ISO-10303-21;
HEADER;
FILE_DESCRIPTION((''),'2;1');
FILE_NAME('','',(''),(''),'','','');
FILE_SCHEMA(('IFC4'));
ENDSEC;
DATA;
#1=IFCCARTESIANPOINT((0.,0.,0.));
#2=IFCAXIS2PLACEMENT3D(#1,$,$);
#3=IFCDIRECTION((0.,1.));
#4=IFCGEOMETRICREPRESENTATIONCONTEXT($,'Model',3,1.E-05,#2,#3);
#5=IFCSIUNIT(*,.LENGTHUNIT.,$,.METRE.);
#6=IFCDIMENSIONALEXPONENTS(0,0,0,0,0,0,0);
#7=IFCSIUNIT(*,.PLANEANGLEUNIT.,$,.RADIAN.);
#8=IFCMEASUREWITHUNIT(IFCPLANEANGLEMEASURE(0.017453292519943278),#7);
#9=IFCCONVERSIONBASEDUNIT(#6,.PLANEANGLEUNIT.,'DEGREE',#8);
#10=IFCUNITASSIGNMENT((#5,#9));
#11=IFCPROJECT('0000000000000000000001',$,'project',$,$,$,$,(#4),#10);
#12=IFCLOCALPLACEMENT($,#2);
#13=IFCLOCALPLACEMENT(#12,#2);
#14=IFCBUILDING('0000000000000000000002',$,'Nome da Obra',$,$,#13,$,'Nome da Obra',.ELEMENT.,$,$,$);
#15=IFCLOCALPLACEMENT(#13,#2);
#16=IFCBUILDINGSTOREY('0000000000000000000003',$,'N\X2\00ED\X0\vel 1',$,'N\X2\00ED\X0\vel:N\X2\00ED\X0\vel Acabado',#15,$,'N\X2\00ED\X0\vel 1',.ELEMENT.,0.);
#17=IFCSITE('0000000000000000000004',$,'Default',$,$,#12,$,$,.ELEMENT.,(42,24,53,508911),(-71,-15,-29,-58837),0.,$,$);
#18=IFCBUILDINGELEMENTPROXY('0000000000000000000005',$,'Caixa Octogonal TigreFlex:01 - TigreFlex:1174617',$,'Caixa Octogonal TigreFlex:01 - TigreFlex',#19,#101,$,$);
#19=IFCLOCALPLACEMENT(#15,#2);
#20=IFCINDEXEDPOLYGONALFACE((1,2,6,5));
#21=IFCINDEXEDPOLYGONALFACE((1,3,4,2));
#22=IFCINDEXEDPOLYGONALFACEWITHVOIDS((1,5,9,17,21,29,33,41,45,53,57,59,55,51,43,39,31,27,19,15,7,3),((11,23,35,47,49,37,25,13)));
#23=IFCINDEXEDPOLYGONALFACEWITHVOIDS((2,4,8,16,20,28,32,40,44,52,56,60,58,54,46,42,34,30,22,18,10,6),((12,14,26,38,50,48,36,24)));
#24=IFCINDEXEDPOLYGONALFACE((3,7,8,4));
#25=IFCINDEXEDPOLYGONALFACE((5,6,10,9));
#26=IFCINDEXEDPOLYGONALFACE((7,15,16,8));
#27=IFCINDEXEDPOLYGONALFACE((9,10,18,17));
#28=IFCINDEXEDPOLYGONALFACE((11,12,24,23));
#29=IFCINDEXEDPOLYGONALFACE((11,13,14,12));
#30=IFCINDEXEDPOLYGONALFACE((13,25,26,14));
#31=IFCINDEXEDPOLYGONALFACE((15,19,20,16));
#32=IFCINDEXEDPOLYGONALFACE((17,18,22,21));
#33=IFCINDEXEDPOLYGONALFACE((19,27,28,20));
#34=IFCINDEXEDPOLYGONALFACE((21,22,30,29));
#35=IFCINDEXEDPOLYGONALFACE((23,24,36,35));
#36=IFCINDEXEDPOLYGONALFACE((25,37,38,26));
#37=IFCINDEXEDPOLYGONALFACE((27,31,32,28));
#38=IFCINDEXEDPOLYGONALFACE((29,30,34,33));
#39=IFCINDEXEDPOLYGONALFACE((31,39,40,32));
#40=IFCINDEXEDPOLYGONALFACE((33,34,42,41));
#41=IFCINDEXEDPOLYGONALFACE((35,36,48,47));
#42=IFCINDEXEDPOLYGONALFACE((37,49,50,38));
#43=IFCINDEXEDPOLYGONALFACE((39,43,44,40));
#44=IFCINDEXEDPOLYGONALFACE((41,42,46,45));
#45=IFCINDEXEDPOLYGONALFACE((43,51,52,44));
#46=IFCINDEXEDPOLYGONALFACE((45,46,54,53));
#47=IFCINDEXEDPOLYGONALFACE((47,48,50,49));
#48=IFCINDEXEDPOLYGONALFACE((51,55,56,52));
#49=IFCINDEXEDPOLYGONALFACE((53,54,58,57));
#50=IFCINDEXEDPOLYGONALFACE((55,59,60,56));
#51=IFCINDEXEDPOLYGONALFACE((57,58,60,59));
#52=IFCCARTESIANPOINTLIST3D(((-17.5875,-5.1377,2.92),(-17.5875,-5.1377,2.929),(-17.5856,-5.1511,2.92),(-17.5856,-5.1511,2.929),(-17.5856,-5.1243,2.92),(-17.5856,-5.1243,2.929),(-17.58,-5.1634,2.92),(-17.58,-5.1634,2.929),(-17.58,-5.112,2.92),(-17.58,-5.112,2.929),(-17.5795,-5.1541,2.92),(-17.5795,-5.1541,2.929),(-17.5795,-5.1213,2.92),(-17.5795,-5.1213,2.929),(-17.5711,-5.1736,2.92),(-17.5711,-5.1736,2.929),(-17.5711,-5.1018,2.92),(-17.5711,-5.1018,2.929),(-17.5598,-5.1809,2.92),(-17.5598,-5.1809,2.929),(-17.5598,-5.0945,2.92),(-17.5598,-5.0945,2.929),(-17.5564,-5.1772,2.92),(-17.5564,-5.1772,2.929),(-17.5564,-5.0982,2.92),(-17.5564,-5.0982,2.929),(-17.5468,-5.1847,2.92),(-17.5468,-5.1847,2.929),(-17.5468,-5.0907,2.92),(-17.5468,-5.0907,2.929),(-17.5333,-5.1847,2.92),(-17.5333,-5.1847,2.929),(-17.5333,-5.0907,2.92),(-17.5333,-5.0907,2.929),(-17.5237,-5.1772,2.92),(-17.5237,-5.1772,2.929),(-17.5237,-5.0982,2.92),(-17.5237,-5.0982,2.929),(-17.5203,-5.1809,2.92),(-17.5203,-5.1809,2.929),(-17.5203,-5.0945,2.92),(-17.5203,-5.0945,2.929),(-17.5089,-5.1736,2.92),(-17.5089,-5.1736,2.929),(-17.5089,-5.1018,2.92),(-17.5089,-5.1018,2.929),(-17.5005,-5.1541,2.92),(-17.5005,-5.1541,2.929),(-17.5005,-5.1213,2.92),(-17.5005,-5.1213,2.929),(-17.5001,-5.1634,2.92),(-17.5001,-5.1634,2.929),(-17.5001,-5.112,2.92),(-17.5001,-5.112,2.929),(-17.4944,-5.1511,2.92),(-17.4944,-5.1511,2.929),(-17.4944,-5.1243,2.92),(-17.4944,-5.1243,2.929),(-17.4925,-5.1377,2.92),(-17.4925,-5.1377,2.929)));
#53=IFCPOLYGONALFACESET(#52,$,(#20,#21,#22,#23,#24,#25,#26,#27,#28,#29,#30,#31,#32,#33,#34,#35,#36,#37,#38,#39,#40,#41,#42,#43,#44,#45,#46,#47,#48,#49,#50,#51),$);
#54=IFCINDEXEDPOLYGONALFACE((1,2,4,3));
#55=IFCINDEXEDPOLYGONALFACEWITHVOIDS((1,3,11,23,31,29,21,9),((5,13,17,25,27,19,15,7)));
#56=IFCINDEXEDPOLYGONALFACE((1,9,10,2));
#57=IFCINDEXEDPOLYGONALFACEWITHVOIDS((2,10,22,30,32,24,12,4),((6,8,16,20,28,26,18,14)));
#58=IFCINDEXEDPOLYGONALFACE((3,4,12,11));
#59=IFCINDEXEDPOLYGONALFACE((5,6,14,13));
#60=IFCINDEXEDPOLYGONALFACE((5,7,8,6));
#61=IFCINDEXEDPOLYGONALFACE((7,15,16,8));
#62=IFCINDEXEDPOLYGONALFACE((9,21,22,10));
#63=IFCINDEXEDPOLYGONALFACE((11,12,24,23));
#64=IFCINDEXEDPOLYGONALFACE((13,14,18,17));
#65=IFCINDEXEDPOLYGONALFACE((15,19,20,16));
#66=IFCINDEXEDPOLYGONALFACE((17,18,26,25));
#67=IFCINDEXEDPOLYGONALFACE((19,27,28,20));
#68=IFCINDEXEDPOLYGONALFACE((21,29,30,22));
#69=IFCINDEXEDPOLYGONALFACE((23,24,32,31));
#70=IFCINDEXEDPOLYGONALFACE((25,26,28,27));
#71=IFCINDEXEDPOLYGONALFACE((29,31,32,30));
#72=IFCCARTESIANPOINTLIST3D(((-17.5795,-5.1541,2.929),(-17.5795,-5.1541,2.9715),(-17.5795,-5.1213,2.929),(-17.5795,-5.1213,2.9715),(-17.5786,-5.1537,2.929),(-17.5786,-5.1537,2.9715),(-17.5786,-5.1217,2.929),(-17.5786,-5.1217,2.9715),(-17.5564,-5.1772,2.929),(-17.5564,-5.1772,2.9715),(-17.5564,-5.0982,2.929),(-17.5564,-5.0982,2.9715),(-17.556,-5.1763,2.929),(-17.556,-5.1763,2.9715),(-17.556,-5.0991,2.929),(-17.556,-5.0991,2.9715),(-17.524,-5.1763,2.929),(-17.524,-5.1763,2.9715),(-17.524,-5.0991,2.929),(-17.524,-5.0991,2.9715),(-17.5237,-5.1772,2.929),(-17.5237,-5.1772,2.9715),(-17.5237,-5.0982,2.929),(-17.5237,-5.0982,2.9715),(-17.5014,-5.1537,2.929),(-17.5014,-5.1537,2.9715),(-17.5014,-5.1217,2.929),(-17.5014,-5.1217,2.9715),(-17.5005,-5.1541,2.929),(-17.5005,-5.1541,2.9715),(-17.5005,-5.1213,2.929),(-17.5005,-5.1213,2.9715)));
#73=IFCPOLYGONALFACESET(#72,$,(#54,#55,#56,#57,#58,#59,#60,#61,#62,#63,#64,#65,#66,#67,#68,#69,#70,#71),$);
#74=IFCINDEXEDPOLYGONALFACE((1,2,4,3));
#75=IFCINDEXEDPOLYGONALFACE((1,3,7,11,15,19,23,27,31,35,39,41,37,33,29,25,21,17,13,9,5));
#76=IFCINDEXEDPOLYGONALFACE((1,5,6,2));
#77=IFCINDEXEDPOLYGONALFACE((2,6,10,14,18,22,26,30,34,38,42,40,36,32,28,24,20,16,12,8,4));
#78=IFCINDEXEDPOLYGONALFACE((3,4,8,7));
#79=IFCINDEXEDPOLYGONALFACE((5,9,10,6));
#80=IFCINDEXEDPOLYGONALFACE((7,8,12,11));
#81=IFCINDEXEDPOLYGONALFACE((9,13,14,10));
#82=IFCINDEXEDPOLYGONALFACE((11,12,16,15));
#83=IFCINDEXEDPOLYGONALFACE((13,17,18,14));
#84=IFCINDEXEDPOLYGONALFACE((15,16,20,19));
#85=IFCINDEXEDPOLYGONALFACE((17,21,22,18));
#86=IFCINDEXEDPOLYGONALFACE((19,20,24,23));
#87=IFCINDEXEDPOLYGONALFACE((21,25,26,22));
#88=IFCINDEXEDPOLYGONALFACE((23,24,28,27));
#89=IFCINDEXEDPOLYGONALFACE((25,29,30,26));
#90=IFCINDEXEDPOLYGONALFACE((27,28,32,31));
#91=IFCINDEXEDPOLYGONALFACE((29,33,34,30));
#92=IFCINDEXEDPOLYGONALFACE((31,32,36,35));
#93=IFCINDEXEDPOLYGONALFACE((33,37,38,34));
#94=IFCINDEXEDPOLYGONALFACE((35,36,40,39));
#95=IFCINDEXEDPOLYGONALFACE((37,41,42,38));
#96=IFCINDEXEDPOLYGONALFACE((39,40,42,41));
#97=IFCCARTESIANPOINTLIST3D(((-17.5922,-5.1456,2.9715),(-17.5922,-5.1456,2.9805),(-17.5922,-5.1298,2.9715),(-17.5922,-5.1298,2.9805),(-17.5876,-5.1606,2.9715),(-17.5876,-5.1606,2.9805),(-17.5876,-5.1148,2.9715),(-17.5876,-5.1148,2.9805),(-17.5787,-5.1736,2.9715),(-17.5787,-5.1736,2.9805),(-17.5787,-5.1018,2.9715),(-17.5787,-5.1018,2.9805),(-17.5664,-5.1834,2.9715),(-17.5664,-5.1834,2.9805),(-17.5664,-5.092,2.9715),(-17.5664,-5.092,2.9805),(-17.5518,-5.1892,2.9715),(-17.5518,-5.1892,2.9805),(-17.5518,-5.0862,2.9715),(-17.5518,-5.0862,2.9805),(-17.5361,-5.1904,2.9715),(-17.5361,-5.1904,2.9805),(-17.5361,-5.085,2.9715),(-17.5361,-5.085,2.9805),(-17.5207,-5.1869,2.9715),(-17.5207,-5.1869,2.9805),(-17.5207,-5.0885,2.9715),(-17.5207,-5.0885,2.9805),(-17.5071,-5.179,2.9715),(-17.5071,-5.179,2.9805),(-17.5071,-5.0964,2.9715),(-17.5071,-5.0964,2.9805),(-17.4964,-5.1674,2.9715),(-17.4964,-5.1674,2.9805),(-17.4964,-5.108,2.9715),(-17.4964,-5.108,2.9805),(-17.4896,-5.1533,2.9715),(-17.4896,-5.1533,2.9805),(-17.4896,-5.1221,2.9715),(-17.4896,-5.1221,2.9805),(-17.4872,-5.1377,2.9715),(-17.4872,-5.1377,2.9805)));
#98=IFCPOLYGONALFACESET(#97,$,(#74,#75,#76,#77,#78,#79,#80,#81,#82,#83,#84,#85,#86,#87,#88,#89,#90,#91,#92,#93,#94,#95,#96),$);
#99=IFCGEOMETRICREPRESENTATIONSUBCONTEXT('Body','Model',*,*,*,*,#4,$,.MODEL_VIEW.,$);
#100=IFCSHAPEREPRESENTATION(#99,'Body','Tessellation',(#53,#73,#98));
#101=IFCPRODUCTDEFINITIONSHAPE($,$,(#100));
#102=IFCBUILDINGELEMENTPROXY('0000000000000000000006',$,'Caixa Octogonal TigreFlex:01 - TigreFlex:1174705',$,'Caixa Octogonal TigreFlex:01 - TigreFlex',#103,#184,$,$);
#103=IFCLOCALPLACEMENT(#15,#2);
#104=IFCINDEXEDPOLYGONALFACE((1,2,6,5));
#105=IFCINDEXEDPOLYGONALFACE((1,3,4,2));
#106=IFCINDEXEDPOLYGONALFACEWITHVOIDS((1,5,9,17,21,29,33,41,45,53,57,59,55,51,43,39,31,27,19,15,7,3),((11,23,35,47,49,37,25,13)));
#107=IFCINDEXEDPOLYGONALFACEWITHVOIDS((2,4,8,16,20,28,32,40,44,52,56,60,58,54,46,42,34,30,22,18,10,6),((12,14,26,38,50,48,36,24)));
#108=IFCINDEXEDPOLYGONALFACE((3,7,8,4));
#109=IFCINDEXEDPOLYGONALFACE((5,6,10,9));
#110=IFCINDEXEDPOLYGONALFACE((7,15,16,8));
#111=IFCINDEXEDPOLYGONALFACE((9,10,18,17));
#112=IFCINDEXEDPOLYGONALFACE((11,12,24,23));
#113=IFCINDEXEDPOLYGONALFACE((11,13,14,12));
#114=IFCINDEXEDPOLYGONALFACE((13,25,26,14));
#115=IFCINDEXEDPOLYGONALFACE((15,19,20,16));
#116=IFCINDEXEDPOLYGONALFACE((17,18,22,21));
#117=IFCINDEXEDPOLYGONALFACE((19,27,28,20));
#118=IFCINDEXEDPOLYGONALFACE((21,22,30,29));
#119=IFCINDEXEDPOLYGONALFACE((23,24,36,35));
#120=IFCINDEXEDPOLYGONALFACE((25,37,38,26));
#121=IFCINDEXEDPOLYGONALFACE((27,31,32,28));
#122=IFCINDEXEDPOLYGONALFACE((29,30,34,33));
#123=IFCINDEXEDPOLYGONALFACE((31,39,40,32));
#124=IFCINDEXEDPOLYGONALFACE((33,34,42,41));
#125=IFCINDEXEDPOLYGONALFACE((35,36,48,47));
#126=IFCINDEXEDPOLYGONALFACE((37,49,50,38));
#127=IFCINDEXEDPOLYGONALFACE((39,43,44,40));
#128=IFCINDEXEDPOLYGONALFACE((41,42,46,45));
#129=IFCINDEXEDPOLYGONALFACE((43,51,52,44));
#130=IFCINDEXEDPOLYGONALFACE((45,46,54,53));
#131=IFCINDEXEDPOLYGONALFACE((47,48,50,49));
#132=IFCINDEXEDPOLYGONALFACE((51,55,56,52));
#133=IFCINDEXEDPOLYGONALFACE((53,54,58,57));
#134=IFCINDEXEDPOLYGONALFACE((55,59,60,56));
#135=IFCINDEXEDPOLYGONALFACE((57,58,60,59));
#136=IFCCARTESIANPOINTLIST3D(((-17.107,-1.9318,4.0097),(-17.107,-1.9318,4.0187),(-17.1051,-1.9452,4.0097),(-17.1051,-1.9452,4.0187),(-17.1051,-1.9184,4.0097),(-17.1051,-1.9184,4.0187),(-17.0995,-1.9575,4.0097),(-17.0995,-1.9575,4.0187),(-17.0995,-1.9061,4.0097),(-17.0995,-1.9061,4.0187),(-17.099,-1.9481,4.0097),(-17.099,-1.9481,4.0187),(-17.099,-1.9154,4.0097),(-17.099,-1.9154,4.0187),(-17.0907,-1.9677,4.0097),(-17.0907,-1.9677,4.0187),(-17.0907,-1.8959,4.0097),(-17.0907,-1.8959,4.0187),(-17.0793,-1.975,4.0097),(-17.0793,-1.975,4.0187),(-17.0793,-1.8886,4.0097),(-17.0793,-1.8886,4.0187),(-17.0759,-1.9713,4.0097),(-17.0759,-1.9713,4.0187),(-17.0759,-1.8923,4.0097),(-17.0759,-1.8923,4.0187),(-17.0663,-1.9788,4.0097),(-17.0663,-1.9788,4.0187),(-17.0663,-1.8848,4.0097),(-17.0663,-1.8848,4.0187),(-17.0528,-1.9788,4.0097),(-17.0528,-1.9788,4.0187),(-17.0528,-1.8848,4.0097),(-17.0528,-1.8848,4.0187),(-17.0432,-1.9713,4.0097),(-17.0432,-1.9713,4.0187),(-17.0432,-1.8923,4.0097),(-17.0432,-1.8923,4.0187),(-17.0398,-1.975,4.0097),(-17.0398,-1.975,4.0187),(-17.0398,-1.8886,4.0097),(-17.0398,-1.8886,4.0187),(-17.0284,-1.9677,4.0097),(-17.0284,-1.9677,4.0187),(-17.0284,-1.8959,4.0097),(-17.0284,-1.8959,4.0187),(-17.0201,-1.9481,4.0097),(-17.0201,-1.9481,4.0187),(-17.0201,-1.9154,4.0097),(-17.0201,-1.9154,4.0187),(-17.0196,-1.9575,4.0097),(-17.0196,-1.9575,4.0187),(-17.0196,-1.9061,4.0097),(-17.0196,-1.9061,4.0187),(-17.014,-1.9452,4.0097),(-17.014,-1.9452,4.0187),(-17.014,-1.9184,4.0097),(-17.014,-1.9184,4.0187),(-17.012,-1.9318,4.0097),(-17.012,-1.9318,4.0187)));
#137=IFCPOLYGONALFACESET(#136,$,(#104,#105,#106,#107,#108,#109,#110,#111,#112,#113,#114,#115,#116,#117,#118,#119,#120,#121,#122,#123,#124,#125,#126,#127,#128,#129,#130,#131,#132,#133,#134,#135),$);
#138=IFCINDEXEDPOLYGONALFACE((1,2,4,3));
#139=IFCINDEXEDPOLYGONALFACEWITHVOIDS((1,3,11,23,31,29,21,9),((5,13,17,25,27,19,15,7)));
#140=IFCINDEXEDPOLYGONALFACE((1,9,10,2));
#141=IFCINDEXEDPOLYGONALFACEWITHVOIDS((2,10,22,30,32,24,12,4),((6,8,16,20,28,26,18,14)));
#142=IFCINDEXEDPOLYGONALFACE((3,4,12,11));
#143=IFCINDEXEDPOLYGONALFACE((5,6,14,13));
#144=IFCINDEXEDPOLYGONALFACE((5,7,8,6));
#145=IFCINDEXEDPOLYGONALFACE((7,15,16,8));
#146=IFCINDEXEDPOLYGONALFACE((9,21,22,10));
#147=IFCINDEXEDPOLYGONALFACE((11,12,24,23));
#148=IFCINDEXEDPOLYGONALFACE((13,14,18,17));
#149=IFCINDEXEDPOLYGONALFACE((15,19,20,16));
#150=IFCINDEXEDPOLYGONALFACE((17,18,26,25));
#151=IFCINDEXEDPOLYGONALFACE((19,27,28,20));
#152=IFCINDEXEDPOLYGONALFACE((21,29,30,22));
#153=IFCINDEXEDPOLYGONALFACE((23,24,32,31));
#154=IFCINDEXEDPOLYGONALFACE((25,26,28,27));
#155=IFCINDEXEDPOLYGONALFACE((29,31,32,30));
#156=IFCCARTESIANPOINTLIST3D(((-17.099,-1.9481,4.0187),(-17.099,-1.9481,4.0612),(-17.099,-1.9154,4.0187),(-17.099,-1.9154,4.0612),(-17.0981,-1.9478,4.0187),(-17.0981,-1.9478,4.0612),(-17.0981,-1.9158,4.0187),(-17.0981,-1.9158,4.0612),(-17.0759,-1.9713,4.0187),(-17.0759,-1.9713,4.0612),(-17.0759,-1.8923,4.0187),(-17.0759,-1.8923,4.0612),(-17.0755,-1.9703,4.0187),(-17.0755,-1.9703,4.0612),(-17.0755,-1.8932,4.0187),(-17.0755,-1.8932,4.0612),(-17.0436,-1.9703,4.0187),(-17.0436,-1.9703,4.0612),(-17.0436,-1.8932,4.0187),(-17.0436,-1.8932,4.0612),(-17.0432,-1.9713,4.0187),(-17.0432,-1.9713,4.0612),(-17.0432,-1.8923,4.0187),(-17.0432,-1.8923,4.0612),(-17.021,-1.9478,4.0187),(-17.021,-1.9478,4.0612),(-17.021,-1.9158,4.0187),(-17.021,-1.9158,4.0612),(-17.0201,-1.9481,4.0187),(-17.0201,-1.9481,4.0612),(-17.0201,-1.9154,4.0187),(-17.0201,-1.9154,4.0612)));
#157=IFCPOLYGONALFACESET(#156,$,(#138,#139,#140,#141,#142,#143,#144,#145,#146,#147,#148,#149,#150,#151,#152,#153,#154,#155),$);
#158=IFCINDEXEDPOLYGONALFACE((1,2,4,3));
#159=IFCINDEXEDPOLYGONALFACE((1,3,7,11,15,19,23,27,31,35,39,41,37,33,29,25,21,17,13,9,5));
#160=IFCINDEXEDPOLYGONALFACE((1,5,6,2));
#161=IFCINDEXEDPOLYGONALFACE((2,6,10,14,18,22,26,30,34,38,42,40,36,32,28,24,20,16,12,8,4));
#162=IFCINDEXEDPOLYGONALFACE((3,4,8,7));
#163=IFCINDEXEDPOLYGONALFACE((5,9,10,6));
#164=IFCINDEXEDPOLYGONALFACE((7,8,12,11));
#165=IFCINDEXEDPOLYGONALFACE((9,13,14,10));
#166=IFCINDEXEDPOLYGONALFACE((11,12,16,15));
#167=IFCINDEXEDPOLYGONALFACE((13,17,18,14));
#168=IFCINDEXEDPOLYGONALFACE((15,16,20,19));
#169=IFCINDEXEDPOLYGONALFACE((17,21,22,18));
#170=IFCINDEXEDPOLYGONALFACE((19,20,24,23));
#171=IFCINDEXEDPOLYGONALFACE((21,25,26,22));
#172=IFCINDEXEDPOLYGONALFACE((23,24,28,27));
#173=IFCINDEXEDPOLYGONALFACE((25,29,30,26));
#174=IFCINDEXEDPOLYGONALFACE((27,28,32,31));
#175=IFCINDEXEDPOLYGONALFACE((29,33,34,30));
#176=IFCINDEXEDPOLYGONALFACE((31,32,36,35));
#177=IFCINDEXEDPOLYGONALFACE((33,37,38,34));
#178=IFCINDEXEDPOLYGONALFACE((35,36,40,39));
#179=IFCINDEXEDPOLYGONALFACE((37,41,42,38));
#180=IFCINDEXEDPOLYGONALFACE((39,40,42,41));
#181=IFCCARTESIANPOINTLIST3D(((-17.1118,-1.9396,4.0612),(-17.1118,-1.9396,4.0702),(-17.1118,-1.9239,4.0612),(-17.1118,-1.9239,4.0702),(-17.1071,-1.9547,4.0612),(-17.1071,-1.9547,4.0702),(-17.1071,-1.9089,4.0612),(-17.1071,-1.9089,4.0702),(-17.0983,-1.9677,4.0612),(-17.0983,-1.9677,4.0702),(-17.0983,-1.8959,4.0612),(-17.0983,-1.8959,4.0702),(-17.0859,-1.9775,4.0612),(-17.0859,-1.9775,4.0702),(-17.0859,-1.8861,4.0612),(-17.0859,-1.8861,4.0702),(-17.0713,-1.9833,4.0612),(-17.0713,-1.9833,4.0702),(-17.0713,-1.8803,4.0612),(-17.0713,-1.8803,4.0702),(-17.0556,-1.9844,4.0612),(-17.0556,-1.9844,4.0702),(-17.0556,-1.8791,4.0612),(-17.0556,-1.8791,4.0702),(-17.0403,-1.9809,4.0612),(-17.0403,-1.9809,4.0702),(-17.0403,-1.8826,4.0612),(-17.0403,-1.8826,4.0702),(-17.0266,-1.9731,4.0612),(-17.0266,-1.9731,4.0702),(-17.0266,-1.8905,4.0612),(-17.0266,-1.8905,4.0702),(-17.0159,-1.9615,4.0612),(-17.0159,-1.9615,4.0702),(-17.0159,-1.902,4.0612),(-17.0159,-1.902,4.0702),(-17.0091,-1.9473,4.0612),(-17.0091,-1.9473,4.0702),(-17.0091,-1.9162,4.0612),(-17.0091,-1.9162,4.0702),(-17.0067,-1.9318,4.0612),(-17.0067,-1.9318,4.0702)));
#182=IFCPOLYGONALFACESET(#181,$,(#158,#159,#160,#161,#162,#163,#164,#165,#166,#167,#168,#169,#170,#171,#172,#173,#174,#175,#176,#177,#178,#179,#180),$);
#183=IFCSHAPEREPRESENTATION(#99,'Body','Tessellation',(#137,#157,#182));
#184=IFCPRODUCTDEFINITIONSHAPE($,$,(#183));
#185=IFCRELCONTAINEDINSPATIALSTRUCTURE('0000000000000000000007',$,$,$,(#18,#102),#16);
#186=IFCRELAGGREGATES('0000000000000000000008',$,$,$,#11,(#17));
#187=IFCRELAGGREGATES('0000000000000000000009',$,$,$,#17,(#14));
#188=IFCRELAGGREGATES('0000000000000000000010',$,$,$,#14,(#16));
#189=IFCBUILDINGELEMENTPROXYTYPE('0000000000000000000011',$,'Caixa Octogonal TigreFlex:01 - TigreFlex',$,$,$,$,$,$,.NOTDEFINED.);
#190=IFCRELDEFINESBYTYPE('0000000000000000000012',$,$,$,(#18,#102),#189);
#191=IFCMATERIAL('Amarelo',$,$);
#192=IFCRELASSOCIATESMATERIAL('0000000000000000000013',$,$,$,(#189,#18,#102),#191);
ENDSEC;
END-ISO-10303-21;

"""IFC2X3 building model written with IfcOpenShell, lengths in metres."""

from ifc_helpers import new_model, entity, si_unit, converted_unit, direction, frame, frame_2d, origin, origin_2d_with_axis, place, context, subcontext, project, spatial, polyline, circle_curve, parameter, trimmed, segment, composite_curve, circle, outline, extrude, source, transform, mapped, material, type_object, type_shapes, element, save


model = new_model("IFC2X3")

# Units and contexts
model_context = context("Model", 3, precision=1e-05, world=origin(), true_north=direction((0.0, 1.0)))
body_context = subcontext(model_context, "Body", "Model", "MODEL_VIEW")
ifc_project = project(units=[si_unit("LENGTHUNIT", "METRE"), converted_unit("PLANEANGLEUNIT", "DEGREE", entity("IfcPlaneAngleMeasure", 0.017453292519943278), si_unit("PLANEANGLEUNIT", "RADIAN"), dimensions=[0, 0, 0, 0, 0, 0, 0])], contexts=[model_context])

# Site, building, storey
site_placement = place(None, origin())
site = spatial("IfcSite", under=ifc_project, at=site_placement, Name="Default", CompositionType="ELEMENT", RefLatitude=(42, 24, 53, 508911), RefLongitude=(-71, -15, -29, -58837), RefElevation=0.0)
building_placement = place(site_placement, origin())
building = spatial("IfcBuilding", under=site, at=building_placement, Name="Nome da Obra", LongName="Nome da Obra", CompositionType="ELEMENT")
storey_placement = place(building_placement, origin())
storey = spatial("IfcBuildingStorey", under=building, at=storey_placement, Name="Nível 1", ObjectType="Nível:Nível Acabado", LongName="Nível 1", CompositionType="ELEMENT", Elevation=0.0)

# Building element proxies
ifc_material_1 = material(Name="Amarelo")
building_element_proxy_type_1 = type_object("IfcBuildingElementProxyType", Name="Caixa Octogonal TigreFlex:01 - TigreFlex", PredefinedType="NOTDEFINED", material=ifc_material_1)
shared_shape_1 = source(origin(), body_context, "Body", "SweptSolid", [
    extrude(outline(composite_curve([segment(trimmed(circle_curve(origin_2d_with_axis(), 0.0475), [parameter(180.0)], [parameter(360.0)], True, "PARAMETER"), True, "CONTINUOUS"), segment(trimmed(circle_curve(origin_2d_with_axis(), 0.0475), [parameter(0.0)], [parameter(180.0)], True, "PARAMETER"), True, "CONTINUOUS")], self_intersect=False), holes=[polyline([(-0.0395, 0.0164), (-0.0164, 0.0395), (0.0164, 0.0395), (0.0395, 0.0164), (0.0395, -0.0164), (0.0164, -0.0395), (-0.0164, -0.0395), (-0.0395, -0.0164), (-0.0395, 0.0164)])]), frame((0.0, 0.0, 2.7698)), (0.0, 0.0, 1.0), 0.009),
    extrude(outline(polyline([(-0.0164, -0.0395), (0.0164, -0.0395), (0.0395, -0.0164), (0.0395, 0.0164), (0.0164, 0.0395), (-0.0164, 0.0395), (-0.0395, 0.0164), (-0.0395, -0.0164), (-0.0164, -0.0395)]), holes=[polyline([(-0.016, -0.0386), (-0.0386, -0.016), (-0.0386, 0.016), (-0.016, 0.0386), (0.016, 0.0386), (0.0386, 0.016), (0.0386, -0.016), (0.016, -0.0386), (-0.016, -0.0386)])]), frame((0.0, 0.0, 2.7788), z_axis=(0.0, 0.0, 1.0), x_axis=(0.0, -1.0, 0.0)), (0.0, 0.0, 1.0), 0.0425),
    extrude(circle(Radius=0.0528, at=frame_2d((0.0, 0.0), x_axis=(1.0, 0.0))), frame((0.0, 0.0, 2.8213)), (0.0, 0.0, 1.0), 0.009),
])
type_shapes(building_element_proxy_type_1, [shared_shape_1])
for number, where, name in (
    (1, (-17.54, -5.1377, 0.1503), "Caixa Octogonal TigreFlex:01 - TigreFlex:1174617"),
    (2, (-17.0595, -1.9318, 1.24), "Caixa Octogonal TigreFlex:01 - TigreFlex:1174705"),
):
    element("IfcBuildingElementProxy", number, at=place(storey_placement, frame(where)), inside=storey, type_object=building_element_proxy_type_1, material=ifc_material_1, Name=name, ObjectType="Caixa Octogonal TigreFlex:01 - TigreFlex", context=body_context, shape_type="MappedRepresentation", body=[
        mapped(shared_shape_1, transform((0.0, 0.0, 0.0), scale=1.0)),
    ])

save(model, "model.ifc")
